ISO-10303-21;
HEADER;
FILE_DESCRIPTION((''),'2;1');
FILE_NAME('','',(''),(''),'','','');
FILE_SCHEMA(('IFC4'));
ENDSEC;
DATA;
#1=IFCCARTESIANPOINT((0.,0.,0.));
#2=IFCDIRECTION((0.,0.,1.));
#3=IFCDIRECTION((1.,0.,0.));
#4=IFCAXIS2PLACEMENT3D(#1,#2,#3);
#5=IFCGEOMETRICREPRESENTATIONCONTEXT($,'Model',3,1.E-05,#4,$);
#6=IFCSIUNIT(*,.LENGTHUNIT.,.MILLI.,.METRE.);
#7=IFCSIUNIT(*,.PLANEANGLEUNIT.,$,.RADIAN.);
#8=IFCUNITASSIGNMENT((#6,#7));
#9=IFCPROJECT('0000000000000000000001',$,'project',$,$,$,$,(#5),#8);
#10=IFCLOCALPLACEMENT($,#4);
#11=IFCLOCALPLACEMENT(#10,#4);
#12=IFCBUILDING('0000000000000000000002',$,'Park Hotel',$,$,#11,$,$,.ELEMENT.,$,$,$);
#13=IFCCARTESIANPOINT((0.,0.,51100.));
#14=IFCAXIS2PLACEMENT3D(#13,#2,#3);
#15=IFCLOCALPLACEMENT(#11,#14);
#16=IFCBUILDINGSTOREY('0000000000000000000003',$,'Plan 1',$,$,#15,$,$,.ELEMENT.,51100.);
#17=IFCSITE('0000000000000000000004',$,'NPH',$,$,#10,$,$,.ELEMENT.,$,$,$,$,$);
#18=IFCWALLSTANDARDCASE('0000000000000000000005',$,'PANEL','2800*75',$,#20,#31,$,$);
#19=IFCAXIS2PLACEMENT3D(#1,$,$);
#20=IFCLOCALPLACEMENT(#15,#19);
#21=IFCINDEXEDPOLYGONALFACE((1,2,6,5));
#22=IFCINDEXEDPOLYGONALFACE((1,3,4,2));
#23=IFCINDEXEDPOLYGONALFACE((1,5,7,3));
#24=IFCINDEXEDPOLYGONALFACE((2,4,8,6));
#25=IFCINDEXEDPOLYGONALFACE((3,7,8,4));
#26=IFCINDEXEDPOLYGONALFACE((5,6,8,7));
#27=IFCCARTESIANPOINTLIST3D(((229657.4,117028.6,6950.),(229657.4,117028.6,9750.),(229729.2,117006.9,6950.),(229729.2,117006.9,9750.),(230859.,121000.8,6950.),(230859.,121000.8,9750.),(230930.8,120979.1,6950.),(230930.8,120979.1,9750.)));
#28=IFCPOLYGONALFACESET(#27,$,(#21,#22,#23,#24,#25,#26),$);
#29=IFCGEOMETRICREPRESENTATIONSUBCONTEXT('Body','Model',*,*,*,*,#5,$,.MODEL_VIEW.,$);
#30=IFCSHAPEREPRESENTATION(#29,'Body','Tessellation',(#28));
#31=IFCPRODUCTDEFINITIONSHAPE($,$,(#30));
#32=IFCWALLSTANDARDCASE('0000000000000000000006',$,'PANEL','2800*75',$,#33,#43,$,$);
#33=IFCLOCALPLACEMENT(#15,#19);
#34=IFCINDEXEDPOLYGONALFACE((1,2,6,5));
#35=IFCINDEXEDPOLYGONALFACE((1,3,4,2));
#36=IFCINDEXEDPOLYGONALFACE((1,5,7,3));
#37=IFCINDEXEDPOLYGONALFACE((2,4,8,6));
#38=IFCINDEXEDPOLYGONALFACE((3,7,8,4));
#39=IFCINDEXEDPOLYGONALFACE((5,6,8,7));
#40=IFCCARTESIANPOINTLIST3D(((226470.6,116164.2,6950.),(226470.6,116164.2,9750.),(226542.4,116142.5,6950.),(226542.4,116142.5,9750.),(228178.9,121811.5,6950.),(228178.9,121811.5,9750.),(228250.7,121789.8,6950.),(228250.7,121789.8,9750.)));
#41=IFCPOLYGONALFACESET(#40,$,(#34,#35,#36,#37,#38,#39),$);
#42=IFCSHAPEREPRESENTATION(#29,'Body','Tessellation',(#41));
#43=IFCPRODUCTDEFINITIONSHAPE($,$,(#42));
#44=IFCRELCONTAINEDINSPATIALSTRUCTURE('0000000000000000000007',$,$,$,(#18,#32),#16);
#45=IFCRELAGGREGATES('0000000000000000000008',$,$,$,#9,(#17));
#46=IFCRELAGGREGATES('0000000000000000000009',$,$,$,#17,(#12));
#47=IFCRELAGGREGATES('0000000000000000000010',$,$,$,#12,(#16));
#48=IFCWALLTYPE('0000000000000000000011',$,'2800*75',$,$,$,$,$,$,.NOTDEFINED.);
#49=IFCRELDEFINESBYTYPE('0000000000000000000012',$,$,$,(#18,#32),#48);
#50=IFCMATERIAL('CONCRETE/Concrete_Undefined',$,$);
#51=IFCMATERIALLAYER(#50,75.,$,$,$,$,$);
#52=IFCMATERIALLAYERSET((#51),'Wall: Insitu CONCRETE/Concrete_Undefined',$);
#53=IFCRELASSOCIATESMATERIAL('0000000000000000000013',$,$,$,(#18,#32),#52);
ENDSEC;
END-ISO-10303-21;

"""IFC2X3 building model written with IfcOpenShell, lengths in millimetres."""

from ifc_helpers import new_model, si_unit, frame, frame_2d, origin_with_axes, place, context, subcontext, project, spatial, rectangle, extrude, material, layer, layer_set, layer_usage, type_object, element, save


model = new_model("IFC2X3")

# Units and contexts
model_context = context("Model", 3, precision=1e-05, world=origin_with_axes())
body_context = subcontext(model_context, "Body", "Model", "MODEL_VIEW")
ifc_project = project(units=[si_unit("LENGTHUNIT", "METRE", prefix="MILLI"), si_unit("PLANEANGLEUNIT", "RADIAN")], contexts=[model_context])

# Site, building, storey
site_placement = place(None, origin_with_axes())
site = spatial("IfcSite", under=ifc_project, at=site_placement, Name="NPH", CompositionType="ELEMENT")
building_placement = place(site_placement, origin_with_axes())
building = spatial("IfcBuilding", under=site, at=building_placement, Name="Park Hotel", CompositionType="ELEMENT")
storey_placement = place(building_placement, frame((0.0, 0.0, 51100.0), z_axis=(0.0, 0.0, 1.0), x_axis=(1.0, 0.0, 0.0)))
storey = spatial("IfcBuildingStorey", under=building, at=storey_placement, Name="Plan 1", CompositionType="ELEMENT", Elevation=51100.0)

# Walls
ifc_material_1 = material(Name="CONCRETE/Concrete_Undefined")
ifc_layer_1 = layer(ifc_material_1, 75.0)
ifc_layer_set_1 = layer_set([ifc_layer_1], Name="Wall: Insitu CONCRETE/Concrete_Undefined")
wall_type_1 = type_object("IfcWallType", Name="2800*75", PredefinedType="NOTDEFINED")
ifc_layer_usage_1 = layer_usage(ifc_layer_set_1, "AXIS2", "POSITIVE", -37.5)
wall_1_placement = place(storey_placement, frame((229693.3, 117017.7, 6950.0), z_axis=(0.0, 0.0, 1.0), x_axis=(0.289537, 0.957167, 0.0)))
element("IfcWallStandardCase", 1, at=wall_1_placement, inside=storey, type_object=wall_type_1, material=ifc_layer_usage_1, Name="PANEL", Description="2800*75", context=body_context, shape_type="SweptSolid", body=[
    extrude(rectangle(XDim=4150.0, YDim=75.0, at=frame_2d((0.0, 2075.0), x_axis=(0.0, -1.0))), frame((0.0, 0.0, 0.0), z_axis=(0.0, 0.0, 1.0), x_axis=(0.0, -1.0, 0.0)), (0.0, 0.0, 1.0), 2800.0),
])
ifc_layer_usage_2 = layer_usage(ifc_layer_set_1, "AXIS2", "POSITIVE", -37.5)
wall_2_placement = place(storey_placement, frame((226506.5, 116153.4, 6950.0), z_axis=(0.0, 0.0, 1.0), x_axis=(0.289537, 0.957167, 0.0)))
element("IfcWallStandardCase", 2, at=wall_2_placement, inside=storey, type_object=wall_type_1, material=ifc_layer_usage_2, Name="PANEL", Description="2800*75", context=body_context, shape_type="SweptSolid", body=[
    extrude(rectangle(XDim=5900.0, YDim=75.0, at=frame_2d((0.0, 2950.0), x_axis=(0.0, -1.0))), frame((0.0, 0.0, 0.0), z_axis=(0.0, 0.0, 1.0), x_axis=(0.0, -1.0, 0.0)), (0.0, 0.0, 1.0), 2800.0),
])

save(model, "model.ifc")
